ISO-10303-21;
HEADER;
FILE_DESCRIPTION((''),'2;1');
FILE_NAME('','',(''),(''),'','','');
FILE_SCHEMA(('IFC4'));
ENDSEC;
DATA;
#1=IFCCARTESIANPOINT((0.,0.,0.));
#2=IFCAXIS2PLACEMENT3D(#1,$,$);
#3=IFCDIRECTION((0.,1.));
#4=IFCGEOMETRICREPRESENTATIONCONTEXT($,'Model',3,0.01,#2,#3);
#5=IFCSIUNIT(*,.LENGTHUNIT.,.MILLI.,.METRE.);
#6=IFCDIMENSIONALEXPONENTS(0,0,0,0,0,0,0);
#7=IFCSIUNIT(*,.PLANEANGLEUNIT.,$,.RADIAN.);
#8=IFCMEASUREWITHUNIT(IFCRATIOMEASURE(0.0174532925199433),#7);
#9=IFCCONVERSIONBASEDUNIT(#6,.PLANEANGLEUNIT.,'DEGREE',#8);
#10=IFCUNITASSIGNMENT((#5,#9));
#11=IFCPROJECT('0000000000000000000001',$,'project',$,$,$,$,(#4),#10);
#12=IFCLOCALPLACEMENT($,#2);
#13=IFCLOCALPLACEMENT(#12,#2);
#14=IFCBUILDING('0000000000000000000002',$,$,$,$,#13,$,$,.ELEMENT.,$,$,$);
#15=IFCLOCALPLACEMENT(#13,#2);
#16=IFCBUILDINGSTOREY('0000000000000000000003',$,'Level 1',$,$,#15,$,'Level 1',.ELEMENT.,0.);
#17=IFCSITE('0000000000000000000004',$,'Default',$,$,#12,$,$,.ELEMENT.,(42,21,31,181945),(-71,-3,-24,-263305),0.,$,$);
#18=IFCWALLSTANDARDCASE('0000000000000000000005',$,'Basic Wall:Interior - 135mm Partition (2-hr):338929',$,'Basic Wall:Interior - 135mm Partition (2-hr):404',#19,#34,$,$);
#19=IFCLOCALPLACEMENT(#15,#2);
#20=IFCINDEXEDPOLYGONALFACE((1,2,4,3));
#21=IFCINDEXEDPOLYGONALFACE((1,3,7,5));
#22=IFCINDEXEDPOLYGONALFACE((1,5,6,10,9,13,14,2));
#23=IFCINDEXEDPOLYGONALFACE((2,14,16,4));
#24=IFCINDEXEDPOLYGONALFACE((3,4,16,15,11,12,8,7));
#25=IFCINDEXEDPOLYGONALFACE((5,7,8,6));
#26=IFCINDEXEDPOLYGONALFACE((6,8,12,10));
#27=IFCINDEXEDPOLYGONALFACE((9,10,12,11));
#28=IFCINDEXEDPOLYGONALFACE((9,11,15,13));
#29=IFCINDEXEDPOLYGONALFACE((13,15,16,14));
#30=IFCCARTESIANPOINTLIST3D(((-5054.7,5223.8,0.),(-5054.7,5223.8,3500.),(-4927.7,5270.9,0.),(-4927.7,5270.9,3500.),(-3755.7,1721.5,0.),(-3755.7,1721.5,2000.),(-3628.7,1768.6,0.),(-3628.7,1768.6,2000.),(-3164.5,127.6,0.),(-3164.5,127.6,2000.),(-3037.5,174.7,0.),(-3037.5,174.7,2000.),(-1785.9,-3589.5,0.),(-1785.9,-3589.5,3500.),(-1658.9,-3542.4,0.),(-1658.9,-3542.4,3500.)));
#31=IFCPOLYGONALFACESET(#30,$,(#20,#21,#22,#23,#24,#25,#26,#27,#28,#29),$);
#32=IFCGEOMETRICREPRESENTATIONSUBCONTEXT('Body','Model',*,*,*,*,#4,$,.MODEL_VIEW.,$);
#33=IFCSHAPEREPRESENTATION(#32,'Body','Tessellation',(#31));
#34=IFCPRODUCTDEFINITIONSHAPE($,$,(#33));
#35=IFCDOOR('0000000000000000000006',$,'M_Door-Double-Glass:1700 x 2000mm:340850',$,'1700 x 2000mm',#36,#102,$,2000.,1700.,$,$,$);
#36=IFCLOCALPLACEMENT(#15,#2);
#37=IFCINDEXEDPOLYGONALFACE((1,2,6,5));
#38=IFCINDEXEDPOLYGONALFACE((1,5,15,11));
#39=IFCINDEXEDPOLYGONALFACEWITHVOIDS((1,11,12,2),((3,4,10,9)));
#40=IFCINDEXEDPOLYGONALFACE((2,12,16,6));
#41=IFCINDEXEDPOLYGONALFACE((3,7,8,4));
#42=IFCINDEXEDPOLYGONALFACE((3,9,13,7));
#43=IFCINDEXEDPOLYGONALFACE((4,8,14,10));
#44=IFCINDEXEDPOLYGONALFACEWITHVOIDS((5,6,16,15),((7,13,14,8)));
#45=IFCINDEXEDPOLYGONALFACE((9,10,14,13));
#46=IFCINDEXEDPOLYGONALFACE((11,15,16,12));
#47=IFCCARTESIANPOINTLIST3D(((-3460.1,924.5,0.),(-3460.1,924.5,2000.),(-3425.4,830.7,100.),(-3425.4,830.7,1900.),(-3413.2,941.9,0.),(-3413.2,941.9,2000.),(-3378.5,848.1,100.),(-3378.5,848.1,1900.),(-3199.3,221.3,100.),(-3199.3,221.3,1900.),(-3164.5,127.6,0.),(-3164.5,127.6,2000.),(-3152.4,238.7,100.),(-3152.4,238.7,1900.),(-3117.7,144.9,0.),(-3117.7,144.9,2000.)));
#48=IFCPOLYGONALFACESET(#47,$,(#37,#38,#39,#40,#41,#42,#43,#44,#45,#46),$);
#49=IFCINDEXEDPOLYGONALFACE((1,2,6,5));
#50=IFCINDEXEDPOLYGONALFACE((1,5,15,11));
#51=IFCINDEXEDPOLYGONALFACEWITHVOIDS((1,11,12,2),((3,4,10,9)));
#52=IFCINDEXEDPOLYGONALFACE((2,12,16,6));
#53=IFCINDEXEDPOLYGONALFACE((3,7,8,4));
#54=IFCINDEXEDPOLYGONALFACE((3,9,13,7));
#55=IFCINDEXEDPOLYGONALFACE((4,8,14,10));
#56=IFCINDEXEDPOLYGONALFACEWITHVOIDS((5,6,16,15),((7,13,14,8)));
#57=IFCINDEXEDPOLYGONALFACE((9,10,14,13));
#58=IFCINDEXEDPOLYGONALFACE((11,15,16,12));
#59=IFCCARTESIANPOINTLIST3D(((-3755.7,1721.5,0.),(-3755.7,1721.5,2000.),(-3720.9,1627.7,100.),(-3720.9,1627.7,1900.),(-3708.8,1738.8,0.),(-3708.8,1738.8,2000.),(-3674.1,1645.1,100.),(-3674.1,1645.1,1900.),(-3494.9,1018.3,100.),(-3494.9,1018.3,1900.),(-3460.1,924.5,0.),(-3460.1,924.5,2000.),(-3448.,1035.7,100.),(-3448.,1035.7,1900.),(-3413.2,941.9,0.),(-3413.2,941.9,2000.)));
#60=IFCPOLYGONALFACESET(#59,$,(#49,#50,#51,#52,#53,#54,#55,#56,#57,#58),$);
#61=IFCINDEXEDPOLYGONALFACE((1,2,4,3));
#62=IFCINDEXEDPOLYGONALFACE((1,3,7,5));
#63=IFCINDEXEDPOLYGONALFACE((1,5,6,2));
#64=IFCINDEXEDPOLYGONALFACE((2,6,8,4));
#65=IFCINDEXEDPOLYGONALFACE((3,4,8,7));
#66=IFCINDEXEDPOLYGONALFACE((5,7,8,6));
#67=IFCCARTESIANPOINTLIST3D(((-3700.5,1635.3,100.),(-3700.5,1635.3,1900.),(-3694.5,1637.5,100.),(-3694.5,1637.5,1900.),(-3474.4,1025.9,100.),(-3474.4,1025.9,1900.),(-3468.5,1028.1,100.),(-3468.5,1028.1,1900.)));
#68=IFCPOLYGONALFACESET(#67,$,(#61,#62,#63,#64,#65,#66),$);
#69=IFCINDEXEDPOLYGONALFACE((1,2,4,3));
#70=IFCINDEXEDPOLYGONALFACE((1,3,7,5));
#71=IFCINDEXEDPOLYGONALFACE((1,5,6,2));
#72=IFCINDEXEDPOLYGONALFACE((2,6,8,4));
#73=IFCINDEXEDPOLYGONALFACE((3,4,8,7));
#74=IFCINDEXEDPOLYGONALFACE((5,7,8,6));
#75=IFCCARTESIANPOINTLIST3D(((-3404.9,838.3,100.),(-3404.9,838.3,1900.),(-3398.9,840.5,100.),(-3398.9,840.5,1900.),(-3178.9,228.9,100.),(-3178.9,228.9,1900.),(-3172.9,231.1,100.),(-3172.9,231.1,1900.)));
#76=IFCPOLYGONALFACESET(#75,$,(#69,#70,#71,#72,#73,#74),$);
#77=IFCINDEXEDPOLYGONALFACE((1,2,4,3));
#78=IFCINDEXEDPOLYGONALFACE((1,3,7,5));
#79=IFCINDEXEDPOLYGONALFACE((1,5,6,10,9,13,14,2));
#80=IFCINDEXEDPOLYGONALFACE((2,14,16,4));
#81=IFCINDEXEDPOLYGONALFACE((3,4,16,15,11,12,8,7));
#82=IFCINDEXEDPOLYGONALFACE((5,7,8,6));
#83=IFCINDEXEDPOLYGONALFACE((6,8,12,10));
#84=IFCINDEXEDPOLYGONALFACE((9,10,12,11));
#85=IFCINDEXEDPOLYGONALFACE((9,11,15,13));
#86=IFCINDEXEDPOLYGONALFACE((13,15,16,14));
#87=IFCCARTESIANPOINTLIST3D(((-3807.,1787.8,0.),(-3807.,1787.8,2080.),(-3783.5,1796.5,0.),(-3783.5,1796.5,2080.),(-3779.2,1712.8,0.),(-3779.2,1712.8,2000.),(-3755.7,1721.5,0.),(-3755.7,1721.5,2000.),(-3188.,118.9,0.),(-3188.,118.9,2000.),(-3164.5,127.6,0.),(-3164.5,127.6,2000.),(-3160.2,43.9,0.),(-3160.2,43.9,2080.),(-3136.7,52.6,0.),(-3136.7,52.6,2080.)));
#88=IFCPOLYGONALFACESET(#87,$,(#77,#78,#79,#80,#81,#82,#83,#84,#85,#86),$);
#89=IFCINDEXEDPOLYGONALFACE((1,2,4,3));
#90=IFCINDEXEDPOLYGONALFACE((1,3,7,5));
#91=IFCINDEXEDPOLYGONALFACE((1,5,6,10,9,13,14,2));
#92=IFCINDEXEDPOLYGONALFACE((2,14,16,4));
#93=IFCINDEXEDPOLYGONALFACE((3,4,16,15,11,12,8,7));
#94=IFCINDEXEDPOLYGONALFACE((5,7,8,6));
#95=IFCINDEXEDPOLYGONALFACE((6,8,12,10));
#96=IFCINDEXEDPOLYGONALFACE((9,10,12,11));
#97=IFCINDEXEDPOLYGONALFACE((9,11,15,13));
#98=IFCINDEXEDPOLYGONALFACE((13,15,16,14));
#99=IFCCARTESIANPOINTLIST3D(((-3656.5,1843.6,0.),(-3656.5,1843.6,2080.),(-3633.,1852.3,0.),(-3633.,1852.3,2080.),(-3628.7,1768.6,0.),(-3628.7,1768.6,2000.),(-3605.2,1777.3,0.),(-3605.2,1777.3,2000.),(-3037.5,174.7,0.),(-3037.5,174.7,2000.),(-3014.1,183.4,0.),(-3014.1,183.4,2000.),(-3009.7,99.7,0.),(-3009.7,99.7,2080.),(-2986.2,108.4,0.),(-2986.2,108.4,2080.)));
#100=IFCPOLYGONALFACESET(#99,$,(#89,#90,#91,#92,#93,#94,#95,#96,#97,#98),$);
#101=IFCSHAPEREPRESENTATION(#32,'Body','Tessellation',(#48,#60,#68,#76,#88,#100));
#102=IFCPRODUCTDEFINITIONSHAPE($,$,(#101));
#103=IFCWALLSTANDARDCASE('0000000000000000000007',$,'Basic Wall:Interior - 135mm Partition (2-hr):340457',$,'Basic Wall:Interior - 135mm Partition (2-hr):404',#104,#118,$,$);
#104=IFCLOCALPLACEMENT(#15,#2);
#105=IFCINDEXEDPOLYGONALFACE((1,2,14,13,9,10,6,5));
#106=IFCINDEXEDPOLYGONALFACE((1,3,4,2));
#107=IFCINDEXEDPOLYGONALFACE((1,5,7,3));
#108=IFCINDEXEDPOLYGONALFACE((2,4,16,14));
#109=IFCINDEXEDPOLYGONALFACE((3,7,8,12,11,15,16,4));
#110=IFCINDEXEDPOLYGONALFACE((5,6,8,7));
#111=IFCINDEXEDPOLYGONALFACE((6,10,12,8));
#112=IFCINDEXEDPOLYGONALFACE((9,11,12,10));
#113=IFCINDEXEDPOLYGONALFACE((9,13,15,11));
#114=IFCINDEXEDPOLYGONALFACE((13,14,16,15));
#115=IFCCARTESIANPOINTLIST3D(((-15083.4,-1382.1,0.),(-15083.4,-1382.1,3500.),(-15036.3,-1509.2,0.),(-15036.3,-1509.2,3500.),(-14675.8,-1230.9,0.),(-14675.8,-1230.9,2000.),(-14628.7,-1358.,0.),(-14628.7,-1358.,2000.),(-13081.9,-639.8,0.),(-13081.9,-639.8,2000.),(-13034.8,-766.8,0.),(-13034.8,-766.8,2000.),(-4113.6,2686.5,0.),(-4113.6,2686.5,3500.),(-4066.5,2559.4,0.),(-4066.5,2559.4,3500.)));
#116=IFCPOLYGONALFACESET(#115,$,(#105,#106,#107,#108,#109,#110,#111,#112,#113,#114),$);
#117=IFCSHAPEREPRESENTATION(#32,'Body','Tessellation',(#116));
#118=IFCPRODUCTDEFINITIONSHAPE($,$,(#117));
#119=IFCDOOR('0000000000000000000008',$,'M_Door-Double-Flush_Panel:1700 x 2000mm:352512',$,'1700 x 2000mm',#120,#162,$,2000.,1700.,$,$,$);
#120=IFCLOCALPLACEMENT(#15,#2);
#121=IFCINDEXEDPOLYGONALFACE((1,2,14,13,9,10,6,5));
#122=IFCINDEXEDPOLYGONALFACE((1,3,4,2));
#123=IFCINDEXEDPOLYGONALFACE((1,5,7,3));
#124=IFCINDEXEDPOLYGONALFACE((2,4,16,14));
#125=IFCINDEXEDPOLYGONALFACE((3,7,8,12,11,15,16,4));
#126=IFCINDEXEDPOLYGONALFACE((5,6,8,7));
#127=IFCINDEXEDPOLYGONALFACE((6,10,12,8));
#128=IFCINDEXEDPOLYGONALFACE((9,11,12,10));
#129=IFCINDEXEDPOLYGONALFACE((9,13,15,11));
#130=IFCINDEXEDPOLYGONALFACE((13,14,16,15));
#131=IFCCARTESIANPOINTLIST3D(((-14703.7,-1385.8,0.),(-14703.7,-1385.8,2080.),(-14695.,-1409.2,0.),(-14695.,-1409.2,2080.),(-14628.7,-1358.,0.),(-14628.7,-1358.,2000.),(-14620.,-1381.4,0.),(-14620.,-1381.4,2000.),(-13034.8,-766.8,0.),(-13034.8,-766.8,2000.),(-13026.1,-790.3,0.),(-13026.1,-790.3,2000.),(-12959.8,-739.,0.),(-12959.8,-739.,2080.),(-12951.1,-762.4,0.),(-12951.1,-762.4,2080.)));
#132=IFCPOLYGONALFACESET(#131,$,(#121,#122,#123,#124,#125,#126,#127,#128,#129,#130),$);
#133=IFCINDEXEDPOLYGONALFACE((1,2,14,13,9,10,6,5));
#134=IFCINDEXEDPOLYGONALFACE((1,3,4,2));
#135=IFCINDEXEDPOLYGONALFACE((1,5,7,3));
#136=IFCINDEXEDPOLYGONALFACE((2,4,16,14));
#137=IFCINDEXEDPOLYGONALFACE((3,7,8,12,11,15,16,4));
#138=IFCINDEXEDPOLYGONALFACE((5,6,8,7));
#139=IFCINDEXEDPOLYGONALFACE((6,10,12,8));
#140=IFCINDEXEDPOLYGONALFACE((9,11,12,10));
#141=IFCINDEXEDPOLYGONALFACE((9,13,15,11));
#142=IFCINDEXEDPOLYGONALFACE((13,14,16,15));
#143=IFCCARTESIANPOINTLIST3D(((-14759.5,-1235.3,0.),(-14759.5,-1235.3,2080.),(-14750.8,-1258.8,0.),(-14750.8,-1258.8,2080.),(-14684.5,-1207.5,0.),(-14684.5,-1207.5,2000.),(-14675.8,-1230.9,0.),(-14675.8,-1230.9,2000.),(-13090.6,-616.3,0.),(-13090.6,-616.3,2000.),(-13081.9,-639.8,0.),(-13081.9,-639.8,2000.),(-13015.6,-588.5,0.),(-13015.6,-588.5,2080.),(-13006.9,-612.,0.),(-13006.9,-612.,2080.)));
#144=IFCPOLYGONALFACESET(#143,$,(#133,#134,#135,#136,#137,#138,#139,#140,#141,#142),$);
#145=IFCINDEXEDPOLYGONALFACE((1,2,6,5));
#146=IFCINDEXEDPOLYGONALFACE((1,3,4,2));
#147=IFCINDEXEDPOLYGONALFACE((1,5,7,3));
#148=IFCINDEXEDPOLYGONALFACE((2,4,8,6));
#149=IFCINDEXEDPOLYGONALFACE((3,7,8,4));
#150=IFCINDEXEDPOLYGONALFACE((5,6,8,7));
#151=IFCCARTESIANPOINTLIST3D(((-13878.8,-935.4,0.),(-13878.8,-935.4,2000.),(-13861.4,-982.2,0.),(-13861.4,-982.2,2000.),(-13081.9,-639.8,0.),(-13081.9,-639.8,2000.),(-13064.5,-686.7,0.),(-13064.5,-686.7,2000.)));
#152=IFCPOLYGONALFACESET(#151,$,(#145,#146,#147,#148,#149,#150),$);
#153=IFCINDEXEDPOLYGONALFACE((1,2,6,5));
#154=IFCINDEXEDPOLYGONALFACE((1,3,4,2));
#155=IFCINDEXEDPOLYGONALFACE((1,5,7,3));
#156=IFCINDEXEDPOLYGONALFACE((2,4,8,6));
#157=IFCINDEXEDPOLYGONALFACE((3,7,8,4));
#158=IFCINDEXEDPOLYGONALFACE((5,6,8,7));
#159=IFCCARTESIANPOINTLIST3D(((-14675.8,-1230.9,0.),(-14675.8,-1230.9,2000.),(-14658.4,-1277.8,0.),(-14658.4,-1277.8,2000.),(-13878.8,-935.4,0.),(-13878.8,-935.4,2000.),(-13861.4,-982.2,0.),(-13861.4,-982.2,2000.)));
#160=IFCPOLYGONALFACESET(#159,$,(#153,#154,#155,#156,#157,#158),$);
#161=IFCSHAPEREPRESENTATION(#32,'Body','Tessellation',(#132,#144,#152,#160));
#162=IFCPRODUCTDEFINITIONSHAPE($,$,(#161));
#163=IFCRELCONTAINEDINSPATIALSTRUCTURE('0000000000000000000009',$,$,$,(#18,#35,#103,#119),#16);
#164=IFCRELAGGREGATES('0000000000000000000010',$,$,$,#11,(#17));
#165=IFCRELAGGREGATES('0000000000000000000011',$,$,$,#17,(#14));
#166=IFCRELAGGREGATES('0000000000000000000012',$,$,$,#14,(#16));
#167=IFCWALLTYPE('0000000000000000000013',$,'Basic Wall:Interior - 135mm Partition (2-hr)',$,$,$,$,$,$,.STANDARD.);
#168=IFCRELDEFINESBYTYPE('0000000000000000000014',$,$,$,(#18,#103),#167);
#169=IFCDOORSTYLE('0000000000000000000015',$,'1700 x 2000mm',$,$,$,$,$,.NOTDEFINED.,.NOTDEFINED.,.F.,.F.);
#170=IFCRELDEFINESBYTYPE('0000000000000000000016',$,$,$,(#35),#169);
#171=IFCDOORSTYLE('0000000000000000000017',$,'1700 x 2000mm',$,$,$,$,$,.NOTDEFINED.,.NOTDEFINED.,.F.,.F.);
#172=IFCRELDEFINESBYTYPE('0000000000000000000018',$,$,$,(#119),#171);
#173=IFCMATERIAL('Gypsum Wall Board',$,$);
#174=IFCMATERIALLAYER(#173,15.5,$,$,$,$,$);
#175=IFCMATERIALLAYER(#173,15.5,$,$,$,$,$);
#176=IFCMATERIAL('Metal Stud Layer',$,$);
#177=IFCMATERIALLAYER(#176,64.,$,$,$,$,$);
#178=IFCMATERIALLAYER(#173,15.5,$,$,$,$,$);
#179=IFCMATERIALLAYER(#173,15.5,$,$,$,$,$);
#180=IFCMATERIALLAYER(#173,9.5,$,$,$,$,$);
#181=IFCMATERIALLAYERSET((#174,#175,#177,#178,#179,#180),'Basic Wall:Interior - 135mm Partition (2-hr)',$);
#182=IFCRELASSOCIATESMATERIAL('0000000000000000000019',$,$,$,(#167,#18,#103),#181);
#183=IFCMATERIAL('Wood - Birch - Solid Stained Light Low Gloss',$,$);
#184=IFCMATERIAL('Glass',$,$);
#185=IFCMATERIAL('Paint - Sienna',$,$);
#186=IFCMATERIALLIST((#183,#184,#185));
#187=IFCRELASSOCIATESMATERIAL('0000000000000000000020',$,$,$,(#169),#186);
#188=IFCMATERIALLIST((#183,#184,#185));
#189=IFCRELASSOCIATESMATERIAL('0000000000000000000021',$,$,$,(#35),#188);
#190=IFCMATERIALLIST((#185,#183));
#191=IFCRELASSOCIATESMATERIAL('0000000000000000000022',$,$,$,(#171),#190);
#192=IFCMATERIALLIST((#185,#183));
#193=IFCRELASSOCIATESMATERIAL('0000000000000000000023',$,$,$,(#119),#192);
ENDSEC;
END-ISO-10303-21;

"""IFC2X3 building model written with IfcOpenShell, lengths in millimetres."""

from ifc_helpers import new_model, entity, si_unit, converted_unit, direction, frame, frame_2d, origin, origin_2d_with_axis, place, context, subcontext, project, spatial, polyline, rectangle, outline, extrude, source, transform, mapped, material, material_list, layer, layer_set, layer_usage, type_object, type_shapes, element, fill, save


model = new_model("IFC2X3")

# Units and contexts
model_context = context("Model", 3, precision=0.01, world=origin(), true_north=direction((0.0, 1.0)))
body_context = subcontext(model_context, "Body", "Model", "MODEL_VIEW")
ifc_project = project(units=[si_unit("LENGTHUNIT", "METRE", prefix="MILLI"), converted_unit("PLANEANGLEUNIT", "DEGREE", entity("IfcRatioMeasure", 0.0174532925199433), si_unit("PLANEANGLEUNIT", "RADIAN"), dimensions=[0, 0, 0, 0, 0, 0, 0])], contexts=[model_context])

# Site, building, storey
site_placement = place(None, origin())
site = spatial("IfcSite", under=ifc_project, at=site_placement, Name="Default", CompositionType="ELEMENT", RefLatitude=(42, 21, 31, 181945), RefLongitude=(-71, -3, -24, -263305), RefElevation=0.0)
building_placement = place(site_placement, origin())
building = spatial("IfcBuilding", under=site, at=building_placement, CompositionType="ELEMENT")
storey_placement = place(building_placement, origin())
storey = spatial("IfcBuildingStorey", under=building, at=storey_placement, Name="Level 1", LongName="Level 1", CompositionType="ELEMENT", Elevation=0.0)

# Walls, openings, doors
ifc_material_1 = material(Name="Gypsum Wall Board")
ifc_layer_1 = layer(ifc_material_1, 15.5)
ifc_layer_2 = layer(ifc_material_1, 15.5)
ifc_material_2 = material(Name="Metal Stud Layer")
ifc_layer_3 = layer(ifc_material_2, 64.0)
ifc_layer_4 = layer(ifc_material_1, 15.5)
ifc_layer_5 = layer(ifc_material_1, 15.5)
ifc_layer_6 = layer(ifc_material_1, 9.5)
ifc_layer_set_1 = layer_set([ifc_layer_1, ifc_layer_2, ifc_layer_3, ifc_layer_4, ifc_layer_5, ifc_layer_6], Name="Basic Wall:Interior - 135mm Partition (2-hr)")
ifc_layer_usage_1 = layer_usage(ifc_layer_set_1, "AXIS2", "NEGATIVE", 67.8)
wall_type_1 = type_object("IfcWallType", Name="Basic Wall:Interior - 135mm Partition (2-hr)", PredefinedType="STANDARD", material=ifc_layer_set_1)
wall_1_placement = place(storey_placement, frame((-1722.4, -3566.0, 0.0), z_axis=(0.0, 0.0, 1.0), x_axis=(-0.347744, 0.937589, 0.0)))
wall_1 = element("IfcWallStandardCase", 1, at=wall_1_placement, inside=storey, type_object=wall_type_1, material=ifc_layer_usage_1, Name="Basic Wall:Interior - 135mm Partition (2-hr):338929", ObjectType="Basic Wall:Interior - 135mm Partition (2-hr):404", context=body_context, shape_type="SweptSolid", body=[
    extrude(rectangle(XDim=9400.0, YDim=135.5, at=frame_2d((4700.0, 0.0), x_axis=(-1.0, 0.0))), origin(), (0.0, 0.0, 1.0), 3500.0),
])
opening_1_placement = place(wall_1_placement, frame((3964.5, -67.7, 0.0)))
opening_1 = element("IfcOpeningElement", 2, at=opening_1_placement, cuts=wall_1, ObjectType="Opening", context=body_context, shape_type="SweptSolid", body=[
    extrude(rectangle(XDim=1700.0, YDim=2000.0, at=frame_2d((1000.0, 850.0), x_axis=(0.0, 1.0))), frame((0.0, 0.0, 0.0), z_axis=(0.0, 1.0, 0.0), x_axis=(0.0, 0.0, 1.0)), (0.0, 0.0, 1.0), 135.5),
])
ifc_material_3 = material(Name="Wood - Birch - Solid Stained Light Low Gloss")
ifc_material_4 = material(Name="Glass")
ifc_material_5 = material(Name="Paint - Sienna")
ifc_material_list_1 = material_list([ifc_material_3, ifc_material_4, ifc_material_5])
ifc_material_list_2 = material_list([ifc_material_3, ifc_material_4, ifc_material_5])
door_style_1 = type_object("IfcDoorStyle", Name="1700 x 2000mm", ConstructionType="NOTDEFINED", OperationType="NOTDEFINED", ParameterTakesPrecedence=False, Sizeable=False, material=ifc_material_list_2)
shared_shape_1 = source(origin(), body_context, "Body", "SweptSolid", [
    extrude(outline(polyline([(-425.0, -1000.0), (425.0, -1000.0), (425.0, 1000.0), (-425.0, 1000.0), (-425.0, -1000.0)]), holes=[polyline([(-325.0, -900.0), (-325.0, 900.0), (325.0, 900.0), (325.0, -900.0), (-325.0, -900.0)])]), frame((425.0, 85.5, 1000.0), z_axis=(0.0, 1.0, 0.0), x_axis=(1.0, 0.0, 0.0)), (0.0, 0.0, 1.0), 50.0),
    extrude(outline(polyline([(-1000.0, -425.0), (1000.0, -425.0), (1000.0, 425.0), (-1000.0, 425.0), (-1000.0, -425.0)]), holes=[polyline([(-900.0, -325.0), (-900.0, 325.0), (900.0, 325.0), (900.0, -325.0), (-900.0, -325.0)])]), frame((1275.0, 85.5, 1000.0), z_axis=(0.0, 1.0, 0.0), x_axis=(0.0, 0.0, -1.0)), (0.0, 0.0, 1.0), 50.0),
    extrude(rectangle(XDim=6.3, YDim=650.0, at=frame_2d((0.0, 0.0), x_axis=(1.0, 0.0))), frame((1275.0, 110.5, 100.0), z_axis=(0.0, 0.0, 1.0), x_axis=(0.0, -1.0, 0.0)), (0.0, 0.0, 1.0), 1800.0),
    extrude(rectangle(XDim=6.3, YDim=650.0, at=frame_2d((0.0, 0.0), x_axis=(1.0, 0.0))), frame((425.0, 110.5, 100.0), z_axis=(0.0, 0.0, 1.0), x_axis=(0.0, -1.0, 0.0)), (0.0, 0.0, 1.0), 1800.0),
    extrude(outline(polyline([(-930.0, -1020.0), (-850.0, -1020.0), (-850.0, 980.0), (850.0, 980.0), (850.0, -1020.0), (930.0, -1020.0), (930.0, 1060.0), (-930.0, 1060.0), (-930.0, -1020.0)])), frame((850.0, 135.5, 1020.0), z_axis=(0.0, 1.0, 0.0), x_axis=(-1.0, 0.0, 0.0)), (0.0, 0.0, 1.0), 25.0),
    extrude(outline(polyline([(-930.0, -1020.0), (-850.0, -1020.0), (-850.0, 980.0), (850.0, 980.0), (850.0, -1020.0), (930.0, -1020.0), (930.0, 1060.0), (-930.0, 1060.0), (-930.0, -1020.0)])), frame((850.0, -25.0, 1020.0), z_axis=(0.0, 1.0, 0.0), x_axis=(-1.0, 0.0, 0.0)), (0.0, 0.0, 1.0), 25.0),
])
type_shapes(door_style_1, [shared_shape_1])
door_1_placement = place(opening_1_placement, origin())
door_1 = element("IfcDoor", 3, at=door_1_placement, inside=storey, type_object=door_style_1, material=ifc_material_list_1, Name="M_Door-Double-Glass:1700 x 2000mm:340850", ObjectType="1700 x 2000mm", OverallHeight=2000.0, OverallWidth=1700.0, context=body_context, shape_type="MappedRepresentation", body=[
    mapped(shared_shape_1, transform((0.0, 0.0, 0.0), scale=1.0)),
])
fill(opening_1, door_1)
ifc_layer_usage_2 = layer_usage(ifc_layer_set_1, "AXIS2", "NEGATIVE", 67.8)
wall_2_placement = place(storey_placement, frame((-4090.1, 2623.0, 0.0), z_axis=(0.0, 0.0, 1.0), x_axis=(-0.937589, -0.347744, 0.0)))
wall_2 = element("IfcWallStandardCase", 4, at=wall_2_placement, inside=storey, type_object=wall_type_1, material=ifc_layer_usage_2, Name="Basic Wall:Interior - 135mm Partition (2-hr):340457", ObjectType="Basic Wall:Interior - 135mm Partition (2-hr):404", context=body_context, shape_type="SweptSolid", body=[
    extrude(rectangle(XDim=11700.0, YDim=135.5, at=frame_2d((5850.0, 0.0), x_axis=(-1.0, 0.0))), origin(), (0.0, 0.0, 1.0), 3500.0),
])
opening_2_placement = place(wall_2_placement, frame((11265.2, 67.7, 0.0)))
opening_2 = element("IfcOpeningElement", 5, at=opening_2_placement, cuts=wall_2, ObjectType="Opening", context=body_context, shape_type="SweptSolid", body=[
    extrude(rectangle(XDim=2000.0, YDim=1700.0, at=frame_2d((1000.0, 850.0), x_axis=(1.0, 0.0))), frame((0.0, 0.0, 0.0), z_axis=(0.0, -1.0, 0.0), x_axis=(0.0, 0.0, 1.0)), (0.0, 0.0, 1.0), 135.5),
])
ifc_material_list_3 = material_list([ifc_material_5, ifc_material_3])
ifc_material_list_4 = material_list([ifc_material_5, ifc_material_3])
door_style_2 = type_object("IfcDoorStyle", Name="1700 x 2000mm", ConstructionType="NOTDEFINED", OperationType="NOTDEFINED", ParameterTakesPrecedence=False, Sizeable=False, material=ifc_material_list_4)
shared_shape_2 = source(origin(), body_context, "Body", "SweptSolid", [
    extrude(outline(polyline([(-980.0, 850.0), (1020.0, 850.0), (1020.0, 930.0), (-1060.0, 930.0), (-1060.0, -930.0), (1020.0, -930.0), (1020.0, -850.0), (-980.0, -850.0), (-980.0, 850.0)])), frame((850.0, -25.0, 1020.0), z_axis=(0.0, 1.0, 0.0), x_axis=(0.0, 0.0, -1.0)), (0.0, 0.0, 1.0), 25.0),
    extrude(outline(polyline([(-980.0, 850.0), (1020.0, 850.0), (1020.0, 930.0), (-1060.0, 930.0), (-1060.0, -930.0), (1020.0, -930.0), (1020.0, -850.0), (-980.0, -850.0), (-980.0, 850.0)])), frame((850.0, 135.5, 1020.0), z_axis=(0.0, 1.0, 0.0), x_axis=(0.0, 0.0, -1.0)), (0.0, 0.0, 1.0), 25.0),
    extrude(rectangle(XDim=50.0, YDim=850.0, at=origin_2d_with_axis()), frame((1275.0, 110.5, 0.0), z_axis=(0.0, 0.0, 1.0), x_axis=(0.0, -1.0, 0.0)), (0.0, 0.0, 1.0), 2000.0),
    extrude(rectangle(XDim=50.0, YDim=850.0, at=frame_2d((0.0, 0.0), x_axis=(1.0, 0.0))), frame((425.0, 110.5, 0.0), z_axis=(0.0, 0.0, 1.0), x_axis=(0.0, -1.0, 0.0)), (0.0, 0.0, 1.0), 2000.0),
])
type_shapes(door_style_2, [shared_shape_2])
door_2_placement = place(opening_2_placement, frame((0.0, 0.0, 0.0), z_axis=(0.0, 0.0, 1.0), x_axis=(-1.0, 0.0, 0.0)))
door_2 = element("IfcDoor", 6, at=door_2_placement, inside=storey, type_object=door_style_2, material=ifc_material_list_3, Name="M_Door-Double-Flush_Panel:1700 x 2000mm:352512", ObjectType="1700 x 2000mm", OverallHeight=2000.0, OverallWidth=1700.0, context=body_context, shape_type="MappedRepresentation", body=[
    mapped(shared_shape_2, transform((0.0, 0.0, 0.0), scale=1.0)),
])
fill(opening_2, door_2)

save(model, "model.ifc")
